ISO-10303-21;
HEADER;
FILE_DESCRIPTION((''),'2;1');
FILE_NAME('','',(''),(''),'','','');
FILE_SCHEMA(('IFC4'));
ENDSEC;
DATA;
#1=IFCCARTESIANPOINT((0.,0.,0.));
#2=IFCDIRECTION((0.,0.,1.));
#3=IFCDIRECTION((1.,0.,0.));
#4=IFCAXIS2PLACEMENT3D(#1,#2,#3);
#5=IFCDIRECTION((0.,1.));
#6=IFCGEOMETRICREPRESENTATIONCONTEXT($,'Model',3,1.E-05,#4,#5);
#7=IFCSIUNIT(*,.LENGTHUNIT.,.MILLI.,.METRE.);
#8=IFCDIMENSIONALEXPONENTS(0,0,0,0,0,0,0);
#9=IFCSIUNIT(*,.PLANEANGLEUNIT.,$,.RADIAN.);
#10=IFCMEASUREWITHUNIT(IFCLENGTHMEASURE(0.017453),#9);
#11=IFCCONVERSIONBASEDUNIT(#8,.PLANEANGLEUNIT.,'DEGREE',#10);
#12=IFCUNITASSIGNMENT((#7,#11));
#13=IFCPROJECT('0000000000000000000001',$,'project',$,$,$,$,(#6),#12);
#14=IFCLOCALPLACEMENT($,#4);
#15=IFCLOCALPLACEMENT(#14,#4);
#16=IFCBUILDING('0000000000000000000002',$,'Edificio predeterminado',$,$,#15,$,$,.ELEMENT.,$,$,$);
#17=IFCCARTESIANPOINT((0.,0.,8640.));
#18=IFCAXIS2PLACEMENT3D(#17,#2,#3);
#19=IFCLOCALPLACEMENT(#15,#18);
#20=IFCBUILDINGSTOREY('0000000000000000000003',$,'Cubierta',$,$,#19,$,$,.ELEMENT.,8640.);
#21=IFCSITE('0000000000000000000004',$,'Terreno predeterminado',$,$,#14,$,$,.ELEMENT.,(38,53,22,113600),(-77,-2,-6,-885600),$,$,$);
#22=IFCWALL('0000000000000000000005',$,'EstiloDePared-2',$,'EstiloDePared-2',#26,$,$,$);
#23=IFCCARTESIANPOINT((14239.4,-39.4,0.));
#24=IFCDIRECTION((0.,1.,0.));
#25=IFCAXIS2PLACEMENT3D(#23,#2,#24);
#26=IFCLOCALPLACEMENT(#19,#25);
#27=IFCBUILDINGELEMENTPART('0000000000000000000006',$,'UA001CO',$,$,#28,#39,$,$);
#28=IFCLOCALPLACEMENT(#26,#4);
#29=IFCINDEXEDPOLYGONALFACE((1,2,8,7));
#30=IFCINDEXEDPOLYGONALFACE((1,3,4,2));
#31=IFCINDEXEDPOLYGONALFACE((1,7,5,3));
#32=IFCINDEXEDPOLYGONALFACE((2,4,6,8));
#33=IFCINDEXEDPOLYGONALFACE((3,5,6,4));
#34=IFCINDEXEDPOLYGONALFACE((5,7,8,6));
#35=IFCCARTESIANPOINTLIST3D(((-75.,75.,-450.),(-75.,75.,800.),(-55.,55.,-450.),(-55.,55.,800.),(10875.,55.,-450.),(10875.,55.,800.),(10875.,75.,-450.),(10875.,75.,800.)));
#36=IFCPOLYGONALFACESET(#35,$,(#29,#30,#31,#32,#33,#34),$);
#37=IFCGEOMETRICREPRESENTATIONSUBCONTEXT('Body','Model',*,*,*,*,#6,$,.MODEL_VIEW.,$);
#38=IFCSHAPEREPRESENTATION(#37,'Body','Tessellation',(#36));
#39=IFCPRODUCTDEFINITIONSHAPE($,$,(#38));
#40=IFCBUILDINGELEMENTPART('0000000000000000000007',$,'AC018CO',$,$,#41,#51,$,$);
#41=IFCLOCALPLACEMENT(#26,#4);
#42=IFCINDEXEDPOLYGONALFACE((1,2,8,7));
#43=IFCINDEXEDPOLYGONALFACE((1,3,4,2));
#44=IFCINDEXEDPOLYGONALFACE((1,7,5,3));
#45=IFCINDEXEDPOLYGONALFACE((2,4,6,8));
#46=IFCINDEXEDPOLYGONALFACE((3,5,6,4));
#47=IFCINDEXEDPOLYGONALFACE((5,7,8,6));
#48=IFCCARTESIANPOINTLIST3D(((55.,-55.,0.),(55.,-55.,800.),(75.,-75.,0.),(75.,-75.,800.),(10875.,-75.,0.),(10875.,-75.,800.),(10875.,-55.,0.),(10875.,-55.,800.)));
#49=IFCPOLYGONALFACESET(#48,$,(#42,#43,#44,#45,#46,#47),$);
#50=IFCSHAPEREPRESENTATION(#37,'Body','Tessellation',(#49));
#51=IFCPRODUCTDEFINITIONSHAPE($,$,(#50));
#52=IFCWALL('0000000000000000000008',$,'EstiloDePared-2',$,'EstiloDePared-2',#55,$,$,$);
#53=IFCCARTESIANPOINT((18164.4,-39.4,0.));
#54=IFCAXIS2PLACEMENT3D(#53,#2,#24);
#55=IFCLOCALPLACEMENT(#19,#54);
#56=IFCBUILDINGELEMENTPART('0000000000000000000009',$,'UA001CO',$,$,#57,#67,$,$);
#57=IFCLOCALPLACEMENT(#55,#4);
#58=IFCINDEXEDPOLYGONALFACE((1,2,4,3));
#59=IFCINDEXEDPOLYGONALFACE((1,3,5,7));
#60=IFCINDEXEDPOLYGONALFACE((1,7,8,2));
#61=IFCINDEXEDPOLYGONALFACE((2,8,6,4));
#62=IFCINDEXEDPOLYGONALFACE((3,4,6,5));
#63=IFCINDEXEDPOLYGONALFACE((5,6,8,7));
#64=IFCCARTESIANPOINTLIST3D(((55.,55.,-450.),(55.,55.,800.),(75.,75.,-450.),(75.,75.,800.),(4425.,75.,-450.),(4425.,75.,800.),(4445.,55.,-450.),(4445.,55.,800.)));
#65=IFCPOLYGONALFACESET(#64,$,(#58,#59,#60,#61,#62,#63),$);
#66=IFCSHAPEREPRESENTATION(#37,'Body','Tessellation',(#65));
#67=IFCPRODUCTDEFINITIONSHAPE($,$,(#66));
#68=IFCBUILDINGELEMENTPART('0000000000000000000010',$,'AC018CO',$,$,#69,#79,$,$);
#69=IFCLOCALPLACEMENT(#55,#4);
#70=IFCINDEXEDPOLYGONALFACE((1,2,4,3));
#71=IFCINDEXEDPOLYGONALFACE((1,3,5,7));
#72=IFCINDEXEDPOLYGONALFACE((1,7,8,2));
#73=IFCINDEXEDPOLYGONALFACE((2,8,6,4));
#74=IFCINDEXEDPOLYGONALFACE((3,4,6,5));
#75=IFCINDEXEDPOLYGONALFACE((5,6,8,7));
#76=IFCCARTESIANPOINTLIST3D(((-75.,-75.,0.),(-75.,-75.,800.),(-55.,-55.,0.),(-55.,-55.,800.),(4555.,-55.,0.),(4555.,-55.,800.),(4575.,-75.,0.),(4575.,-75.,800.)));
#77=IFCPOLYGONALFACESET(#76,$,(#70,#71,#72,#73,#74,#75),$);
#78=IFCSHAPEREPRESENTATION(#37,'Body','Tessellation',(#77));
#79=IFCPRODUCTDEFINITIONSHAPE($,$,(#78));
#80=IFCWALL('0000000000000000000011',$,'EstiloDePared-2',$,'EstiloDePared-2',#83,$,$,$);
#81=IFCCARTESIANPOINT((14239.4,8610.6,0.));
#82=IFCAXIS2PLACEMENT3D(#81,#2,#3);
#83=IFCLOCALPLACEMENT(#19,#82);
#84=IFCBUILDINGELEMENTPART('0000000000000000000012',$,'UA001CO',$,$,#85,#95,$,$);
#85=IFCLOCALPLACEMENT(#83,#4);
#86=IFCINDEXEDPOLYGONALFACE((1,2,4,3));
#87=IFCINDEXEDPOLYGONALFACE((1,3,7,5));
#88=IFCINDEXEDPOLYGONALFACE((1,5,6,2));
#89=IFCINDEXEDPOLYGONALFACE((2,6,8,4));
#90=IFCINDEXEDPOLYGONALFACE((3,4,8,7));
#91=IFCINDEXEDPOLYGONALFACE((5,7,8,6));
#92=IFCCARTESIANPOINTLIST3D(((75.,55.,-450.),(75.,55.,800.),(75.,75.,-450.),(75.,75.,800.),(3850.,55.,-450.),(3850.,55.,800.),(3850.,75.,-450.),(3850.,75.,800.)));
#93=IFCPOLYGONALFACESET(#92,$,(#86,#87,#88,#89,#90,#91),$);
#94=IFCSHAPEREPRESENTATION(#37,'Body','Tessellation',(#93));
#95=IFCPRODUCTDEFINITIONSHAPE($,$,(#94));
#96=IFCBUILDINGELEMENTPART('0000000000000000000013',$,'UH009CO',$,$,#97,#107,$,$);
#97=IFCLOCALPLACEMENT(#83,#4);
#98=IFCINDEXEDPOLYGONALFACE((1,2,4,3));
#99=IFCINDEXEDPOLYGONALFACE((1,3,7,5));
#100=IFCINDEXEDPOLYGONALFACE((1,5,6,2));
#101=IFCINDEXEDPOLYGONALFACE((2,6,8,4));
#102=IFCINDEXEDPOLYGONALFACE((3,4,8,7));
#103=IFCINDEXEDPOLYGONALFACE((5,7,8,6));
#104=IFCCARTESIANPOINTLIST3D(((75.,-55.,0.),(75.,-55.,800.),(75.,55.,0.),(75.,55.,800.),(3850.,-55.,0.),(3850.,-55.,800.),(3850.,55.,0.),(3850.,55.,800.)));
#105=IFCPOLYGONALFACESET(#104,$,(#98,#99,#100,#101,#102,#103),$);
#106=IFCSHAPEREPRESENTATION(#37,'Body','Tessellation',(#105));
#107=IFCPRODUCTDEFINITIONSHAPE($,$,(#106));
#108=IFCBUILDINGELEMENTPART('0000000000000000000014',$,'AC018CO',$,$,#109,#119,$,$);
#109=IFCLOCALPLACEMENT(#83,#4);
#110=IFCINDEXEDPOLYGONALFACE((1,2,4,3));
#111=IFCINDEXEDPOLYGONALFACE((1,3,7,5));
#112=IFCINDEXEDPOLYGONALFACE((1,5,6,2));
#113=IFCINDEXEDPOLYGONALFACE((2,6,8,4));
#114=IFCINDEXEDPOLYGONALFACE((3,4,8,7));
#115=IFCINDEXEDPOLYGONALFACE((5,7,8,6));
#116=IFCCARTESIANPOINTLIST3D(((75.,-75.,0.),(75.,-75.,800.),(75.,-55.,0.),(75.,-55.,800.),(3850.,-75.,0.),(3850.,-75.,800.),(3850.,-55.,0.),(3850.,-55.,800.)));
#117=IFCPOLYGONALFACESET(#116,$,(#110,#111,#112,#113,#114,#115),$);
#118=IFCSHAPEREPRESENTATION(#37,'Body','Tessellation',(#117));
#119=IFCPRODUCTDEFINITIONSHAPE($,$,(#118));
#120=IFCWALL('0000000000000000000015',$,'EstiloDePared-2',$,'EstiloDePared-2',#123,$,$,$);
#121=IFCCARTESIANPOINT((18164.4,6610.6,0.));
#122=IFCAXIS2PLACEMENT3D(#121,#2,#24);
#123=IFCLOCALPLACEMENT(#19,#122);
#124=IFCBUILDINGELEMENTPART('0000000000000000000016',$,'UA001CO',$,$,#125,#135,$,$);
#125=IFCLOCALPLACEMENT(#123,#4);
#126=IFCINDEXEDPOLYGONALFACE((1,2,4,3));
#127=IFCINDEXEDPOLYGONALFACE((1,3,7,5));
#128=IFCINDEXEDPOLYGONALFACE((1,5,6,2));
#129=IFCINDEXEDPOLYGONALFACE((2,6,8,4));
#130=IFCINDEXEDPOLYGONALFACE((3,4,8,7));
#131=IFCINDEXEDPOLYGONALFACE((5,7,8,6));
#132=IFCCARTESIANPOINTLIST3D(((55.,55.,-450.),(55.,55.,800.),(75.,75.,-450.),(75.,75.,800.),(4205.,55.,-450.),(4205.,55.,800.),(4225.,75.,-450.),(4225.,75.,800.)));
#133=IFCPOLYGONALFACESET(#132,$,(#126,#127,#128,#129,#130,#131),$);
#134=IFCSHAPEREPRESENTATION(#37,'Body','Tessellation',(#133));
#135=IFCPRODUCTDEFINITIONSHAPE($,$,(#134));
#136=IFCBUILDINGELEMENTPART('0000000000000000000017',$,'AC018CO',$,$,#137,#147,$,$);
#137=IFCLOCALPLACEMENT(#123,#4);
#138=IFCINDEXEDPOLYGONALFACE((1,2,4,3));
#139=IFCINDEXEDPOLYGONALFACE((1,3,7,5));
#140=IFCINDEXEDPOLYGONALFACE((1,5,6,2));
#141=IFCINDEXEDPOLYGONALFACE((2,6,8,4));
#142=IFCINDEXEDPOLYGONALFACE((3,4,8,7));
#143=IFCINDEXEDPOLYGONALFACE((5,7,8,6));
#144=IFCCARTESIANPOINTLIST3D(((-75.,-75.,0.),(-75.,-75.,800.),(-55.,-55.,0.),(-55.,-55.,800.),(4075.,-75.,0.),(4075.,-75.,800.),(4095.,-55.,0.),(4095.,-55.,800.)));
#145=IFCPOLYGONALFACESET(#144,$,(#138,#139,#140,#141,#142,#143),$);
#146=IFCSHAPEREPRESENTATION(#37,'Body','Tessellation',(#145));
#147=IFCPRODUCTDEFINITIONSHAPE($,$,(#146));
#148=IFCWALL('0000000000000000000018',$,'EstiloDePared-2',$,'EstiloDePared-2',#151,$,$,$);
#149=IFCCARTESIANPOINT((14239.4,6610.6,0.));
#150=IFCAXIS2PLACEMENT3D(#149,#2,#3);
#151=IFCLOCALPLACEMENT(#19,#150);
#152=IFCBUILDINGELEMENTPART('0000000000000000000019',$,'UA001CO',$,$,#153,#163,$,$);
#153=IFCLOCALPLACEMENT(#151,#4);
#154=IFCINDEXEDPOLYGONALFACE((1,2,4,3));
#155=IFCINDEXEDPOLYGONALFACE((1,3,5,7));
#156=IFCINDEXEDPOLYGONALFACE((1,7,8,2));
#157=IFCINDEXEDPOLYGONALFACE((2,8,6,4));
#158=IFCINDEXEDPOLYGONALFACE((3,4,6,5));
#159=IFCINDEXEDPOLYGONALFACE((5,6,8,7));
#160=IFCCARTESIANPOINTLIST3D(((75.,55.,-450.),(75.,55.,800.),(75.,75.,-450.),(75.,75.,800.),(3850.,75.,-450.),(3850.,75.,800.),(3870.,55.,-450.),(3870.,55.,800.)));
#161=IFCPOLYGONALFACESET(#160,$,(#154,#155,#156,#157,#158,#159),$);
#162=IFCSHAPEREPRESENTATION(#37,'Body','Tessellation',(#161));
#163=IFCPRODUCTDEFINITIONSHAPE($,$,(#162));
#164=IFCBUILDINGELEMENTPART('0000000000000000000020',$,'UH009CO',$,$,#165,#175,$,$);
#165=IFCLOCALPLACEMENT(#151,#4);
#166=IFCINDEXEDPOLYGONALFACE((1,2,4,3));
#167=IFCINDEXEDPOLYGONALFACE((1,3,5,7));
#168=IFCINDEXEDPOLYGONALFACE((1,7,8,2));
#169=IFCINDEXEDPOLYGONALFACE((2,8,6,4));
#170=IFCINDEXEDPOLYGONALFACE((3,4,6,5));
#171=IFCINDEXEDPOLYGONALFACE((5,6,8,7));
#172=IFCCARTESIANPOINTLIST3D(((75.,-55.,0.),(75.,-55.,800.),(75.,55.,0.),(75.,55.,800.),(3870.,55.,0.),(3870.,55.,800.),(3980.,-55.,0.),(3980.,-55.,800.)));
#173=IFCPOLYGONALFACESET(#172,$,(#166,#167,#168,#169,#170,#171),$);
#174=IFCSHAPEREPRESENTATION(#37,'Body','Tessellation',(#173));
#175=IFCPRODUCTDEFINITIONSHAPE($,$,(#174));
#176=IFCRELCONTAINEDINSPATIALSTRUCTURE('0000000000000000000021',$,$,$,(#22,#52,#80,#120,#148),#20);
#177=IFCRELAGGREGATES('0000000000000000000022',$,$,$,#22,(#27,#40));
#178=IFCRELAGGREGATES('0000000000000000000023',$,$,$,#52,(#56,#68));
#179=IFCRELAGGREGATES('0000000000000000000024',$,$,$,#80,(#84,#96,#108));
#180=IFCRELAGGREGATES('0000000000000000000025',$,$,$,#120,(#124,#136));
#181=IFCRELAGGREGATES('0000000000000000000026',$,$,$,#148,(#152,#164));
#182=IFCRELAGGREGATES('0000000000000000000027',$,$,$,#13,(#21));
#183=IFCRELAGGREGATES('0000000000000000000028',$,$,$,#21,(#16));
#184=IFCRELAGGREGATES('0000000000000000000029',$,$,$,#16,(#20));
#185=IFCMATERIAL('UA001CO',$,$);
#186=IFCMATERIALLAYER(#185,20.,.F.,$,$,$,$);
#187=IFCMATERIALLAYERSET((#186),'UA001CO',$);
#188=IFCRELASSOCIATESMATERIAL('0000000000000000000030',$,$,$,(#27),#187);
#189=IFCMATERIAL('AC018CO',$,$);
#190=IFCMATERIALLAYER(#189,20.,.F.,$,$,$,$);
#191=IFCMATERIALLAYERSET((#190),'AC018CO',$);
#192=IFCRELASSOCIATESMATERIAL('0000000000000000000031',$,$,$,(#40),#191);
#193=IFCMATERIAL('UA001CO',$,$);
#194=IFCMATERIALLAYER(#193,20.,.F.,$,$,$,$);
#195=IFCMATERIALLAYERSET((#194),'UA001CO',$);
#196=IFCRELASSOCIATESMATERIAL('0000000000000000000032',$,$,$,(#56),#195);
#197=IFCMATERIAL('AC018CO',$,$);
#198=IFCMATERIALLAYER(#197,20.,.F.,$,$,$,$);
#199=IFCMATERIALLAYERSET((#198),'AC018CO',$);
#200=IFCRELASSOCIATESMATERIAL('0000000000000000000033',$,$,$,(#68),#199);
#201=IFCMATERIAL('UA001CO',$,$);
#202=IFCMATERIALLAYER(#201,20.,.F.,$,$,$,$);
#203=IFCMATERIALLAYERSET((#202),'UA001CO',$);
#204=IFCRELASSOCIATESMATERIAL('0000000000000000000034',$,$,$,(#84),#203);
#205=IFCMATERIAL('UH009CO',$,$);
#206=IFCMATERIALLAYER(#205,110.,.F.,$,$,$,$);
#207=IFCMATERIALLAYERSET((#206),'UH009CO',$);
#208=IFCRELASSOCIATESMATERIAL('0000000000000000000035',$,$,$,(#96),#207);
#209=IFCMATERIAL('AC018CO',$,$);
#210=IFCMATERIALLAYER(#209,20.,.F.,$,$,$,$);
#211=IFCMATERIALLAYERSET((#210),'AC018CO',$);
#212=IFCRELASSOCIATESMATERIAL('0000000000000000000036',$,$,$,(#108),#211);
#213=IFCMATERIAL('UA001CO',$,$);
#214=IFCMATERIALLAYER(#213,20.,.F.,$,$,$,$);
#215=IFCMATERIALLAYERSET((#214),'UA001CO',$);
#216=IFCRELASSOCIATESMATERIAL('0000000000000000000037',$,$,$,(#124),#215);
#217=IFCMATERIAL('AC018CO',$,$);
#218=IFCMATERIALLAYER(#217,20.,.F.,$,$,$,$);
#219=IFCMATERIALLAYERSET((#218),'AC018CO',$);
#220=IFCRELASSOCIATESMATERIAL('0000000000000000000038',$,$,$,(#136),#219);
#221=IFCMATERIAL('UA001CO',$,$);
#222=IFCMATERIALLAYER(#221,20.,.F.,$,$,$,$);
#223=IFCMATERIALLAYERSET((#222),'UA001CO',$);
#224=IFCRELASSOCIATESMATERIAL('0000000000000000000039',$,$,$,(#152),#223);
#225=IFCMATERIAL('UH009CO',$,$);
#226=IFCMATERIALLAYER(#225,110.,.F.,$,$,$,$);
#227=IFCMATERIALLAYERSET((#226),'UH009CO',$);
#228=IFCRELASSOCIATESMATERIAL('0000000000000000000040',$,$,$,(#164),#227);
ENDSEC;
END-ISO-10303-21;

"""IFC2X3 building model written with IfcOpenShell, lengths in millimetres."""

from ifc_helpers import new_model, entity, si_unit, converted_unit, direction, frame, origin_with_axes, place, context, subcontext, project, spatial, polyline, outline, extrude, material, layer, layer_set, layer_usage, element, aggregate, save


model = new_model("IFC2X3")

# Units and contexts
model_context = context("Model", 3, precision=1e-05, world=origin_with_axes(), true_north=direction((0.0, 1.0)))
body_context = subcontext(model_context, "Body", "Model", "MODEL_VIEW")
ifc_project = project(units=[si_unit("LENGTHUNIT", "METRE", prefix="MILLI"), converted_unit("PLANEANGLEUNIT", "DEGREE", entity("IfcLengthMeasure", 0.017453), si_unit("PLANEANGLEUNIT", "RADIAN"), dimensions=[0, 0, 0, 0, 0, 0, 0])], contexts=[model_context])

# Site, building, storey
site_placement = place(None, origin_with_axes())
site = spatial("IfcSite", under=ifc_project, at=site_placement, Name="Terreno predeterminado", CompositionType="ELEMENT", RefLatitude=(38, 53, 22, 113600), RefLongitude=(-77, -2, -6, -885600))
building_placement = place(site_placement, origin_with_axes())
building = spatial("IfcBuilding", under=site, at=building_placement, Name="Edificio predeterminado", CompositionType="ELEMENT")
storey_placement = place(building_placement, frame((0.0, 0.0, 8640.0), z_axis=(0.0, 0.0, 1.0), x_axis=(1.0, 0.0, 0.0)))
storey = spatial("IfcBuildingStorey", under=building, at=storey_placement, Name="Cubierta", CompositionType="ELEMENT", Elevation=8640.0)

# Walls, building element parts
wall_1_placement = place(storey_placement, frame((14239.4, -39.4, 0.0), z_axis=(0.0, 0.0, 1.0), x_axis=(0.0, 1.0, 0.0)))
wall_1 = element("IfcWall", 1, at=wall_1_placement, inside=storey, Name="EstiloDePared-2", ObjectType="EstiloDePared-2")
ifc_material_1 = material(Name="UA001CO")
ifc_layer_1 = layer(ifc_material_1, 20.0, ventilated=False)
ifc_layer_set_1 = layer_set([ifc_layer_1], Name="UA001CO")
ifc_layer_usage_1 = layer_usage(ifc_layer_set_1, "AXIS2", "NEGATIVE", -75.0)
building_element_part_1_placement = place(wall_1_placement, origin_with_axes())
building_element_part_1 = element("IfcBuildingElementPart", 2, at=building_element_part_1_placement, material=ifc_layer_usage_1, Name="UA001CO", context=body_context, shape_type="SweptSolid", body=[
    extrude(outline(polyline([(10875.0, 75.0), (10875.0, 55.0), (-55.0, 55.0), (-75.0, 75.0), (10875.0, 75.0)])), frame((0.0, 0.0, -450.0), z_axis=(0.0, 0.0, 1.0), x_axis=(1.0, 0.0, 0.0)), (0.0, 0.0, 1.0), 1250.0),
])
ifc_material_2 = material(Name="AC018CO")
ifc_layer_2 = layer(ifc_material_2, 20.0, ventilated=False)
ifc_layer_set_2 = layer_set([ifc_layer_2], Name="AC018CO")
ifc_layer_usage_2 = layer_usage(ifc_layer_set_2, "AXIS2", "NEGATIVE", 55.0)
building_element_part_2_placement = place(wall_1_placement, origin_with_axes())
building_element_part_2 = element("IfcBuildingElementPart", 3, at=building_element_part_2_placement, material=ifc_layer_usage_2, Name="AC018CO", context=body_context, shape_type="SweptSolid", body=[
    extrude(outline(polyline([(10875.0, -55.0), (10875.0, -75.0), (75.0, -75.0), (55.0, -55.0), (10875.0, -55.0)])), origin_with_axes(), (0.0, 0.0, 1.0), 800.0),
])
aggregate(wall_1, [building_element_part_1, building_element_part_2])
wall_2_placement = place(storey_placement, frame((18164.4, -39.4, 0.0), z_axis=(0.0, 0.0, 1.0), x_axis=(0.0, 1.0, 0.0)))
wall_2 = element("IfcWall", 4, at=wall_2_placement, inside=storey, Name="EstiloDePared-2", ObjectType="EstiloDePared-2")
ifc_material_3 = material(Name="UA001CO")
ifc_layer_3 = layer(ifc_material_3, 20.0, ventilated=False)
ifc_layer_set_3 = layer_set([ifc_layer_3], Name="UA001CO")
ifc_layer_usage_3 = layer_usage(ifc_layer_set_3, "AXIS2", "NEGATIVE", -75.0)
building_element_part_3_placement = place(wall_2_placement, origin_with_axes())
building_element_part_3 = element("IfcBuildingElementPart", 5, at=building_element_part_3_placement, material=ifc_layer_usage_3, Name="UA001CO", context=body_context, shape_type="SweptSolid", body=[
    extrude(outline(polyline([(4425.0, 75.0), (4445.0, 55.0), (55.0, 55.0), (75.0, 75.0), (4425.0, 75.0)])), frame((0.0, 0.0, -450.0), z_axis=(0.0, 0.0, 1.0), x_axis=(1.0, 0.0, 0.0)), (0.0, 0.0, 1.0), 1250.0),
])
ifc_material_4 = material(Name="AC018CO")
ifc_layer_4 = layer(ifc_material_4, 20.0, ventilated=False)
ifc_layer_set_4 = layer_set([ifc_layer_4], Name="AC018CO")
ifc_layer_usage_4 = layer_usage(ifc_layer_set_4, "AXIS2", "NEGATIVE", 55.0)
building_element_part_4_placement = place(wall_2_placement, origin_with_axes())
building_element_part_4 = element("IfcBuildingElementPart", 6, at=building_element_part_4_placement, material=ifc_layer_usage_4, Name="AC018CO", context=body_context, shape_type="SweptSolid", body=[
    extrude(outline(polyline([(4555.0, -55.0), (4575.0, -75.0), (-75.0, -75.0), (-55.0, -55.0), (4555.0, -55.0)])), origin_with_axes(), (0.0, 0.0, 1.0), 800.0),
])
aggregate(wall_2, [building_element_part_3, building_element_part_4])
wall_3_placement = place(storey_placement, frame((14239.4, 8610.6, 0.0), z_axis=(0.0, 0.0, 1.0), x_axis=(1.0, 0.0, 0.0)))
wall_3 = element("IfcWall", 7, at=wall_3_placement, inside=storey, Name="EstiloDePared-2", ObjectType="EstiloDePared-2")
ifc_material_5 = material(Name="UA001CO")
ifc_layer_5 = layer(ifc_material_5, 20.0, ventilated=False)
ifc_layer_set_5 = layer_set([ifc_layer_5], Name="UA001CO")
ifc_layer_usage_5 = layer_usage(ifc_layer_set_5, "AXIS2", "NEGATIVE", -75.0)
building_element_part_5_placement = place(wall_3_placement, origin_with_axes())
building_element_part_5 = element("IfcBuildingElementPart", 8, at=building_element_part_5_placement, material=ifc_layer_usage_5, Name="UA001CO", context=body_context, shape_type="SweptSolid", body=[
    extrude(outline(polyline([(3850.0, 75.0), (3850.0, 55.0), (75.0, 55.0), (75.0, 75.0), (3850.0, 75.0)])), frame((0.0, 0.0, -450.0), z_axis=(0.0, 0.0, 1.0), x_axis=(1.0, 0.0, 0.0)), (0.0, 0.0, 1.0), 1250.0),
])
ifc_material_6 = material(Name="UH009CO")
ifc_layer_6 = layer(ifc_material_6, 110.0, ventilated=False)
ifc_layer_set_6 = layer_set([ifc_layer_6], Name="UH009CO")
ifc_layer_usage_6 = layer_usage(ifc_layer_set_6, "AXIS2", "NEGATIVE", -55.0)
building_element_part_6_placement = place(wall_3_placement, origin_with_axes())
building_element_part_6 = element("IfcBuildingElementPart", 9, at=building_element_part_6_placement, material=ifc_layer_usage_6, Name="UH009CO", context=body_context, shape_type="SweptSolid", body=[
    extrude(outline(polyline([(3850.0, 55.0), (3850.0, -55.0), (75.0, -55.0), (75.0, 55.0), (3850.0, 55.0)])), origin_with_axes(), (0.0, 0.0, 1.0), 800.0),
])
ifc_material_7 = material(Name="AC018CO")
ifc_layer_7 = layer(ifc_material_7, 20.0, ventilated=False)
ifc_layer_set_7 = layer_set([ifc_layer_7], Name="AC018CO")
ifc_layer_usage_7 = layer_usage(ifc_layer_set_7, "AXIS2", "NEGATIVE", 55.0)
building_element_part_7_placement = place(wall_3_placement, origin_with_axes())
building_element_part_7 = element("IfcBuildingElementPart", 10, at=building_element_part_7_placement, material=ifc_layer_usage_7, Name="AC018CO", context=body_context, shape_type="SweptSolid", body=[
    extrude(outline(polyline([(3850.0, -55.0), (3850.0, -75.0), (75.0, -75.0), (75.0, -55.0), (3850.0, -55.0)])), origin_with_axes(), (0.0, 0.0, 1.0), 800.0),
])
aggregate(wall_3, [building_element_part_5, building_element_part_6, building_element_part_7])
wall_4_placement = place(storey_placement, frame((18164.4, 6610.6, 0.0), z_axis=(0.0, 0.0, 1.0), x_axis=(0.0, 1.0, 0.0)))
wall_4 = element("IfcWall", 11, at=wall_4_placement, inside=storey, Name="EstiloDePared-2", ObjectType="EstiloDePared-2")
ifc_material_8 = material(Name="UA001CO")
ifc_layer_8 = layer(ifc_material_8, 20.0, ventilated=False)
ifc_layer_set_8 = layer_set([ifc_layer_8], Name="UA001CO")
ifc_layer_usage_8 = layer_usage(ifc_layer_set_8, "AXIS2", "NEGATIVE", -75.0)
building_element_part_8_placement = place(wall_4_placement, origin_with_axes())
building_element_part_8 = element("IfcBuildingElementPart", 12, at=building_element_part_8_placement, material=ifc_layer_usage_8, Name="UA001CO", context=body_context, shape_type="SweptSolid", body=[
    extrude(outline(polyline([(4225.0, 75.0), (4205.0, 55.0), (55.0, 55.0), (75.0, 75.0), (4225.0, 75.0)])), frame((0.0, 0.0, -450.0), z_axis=(0.0, 0.0, 1.0), x_axis=(1.0, 0.0, 0.0)), (0.0, 0.0, 1.0), 1250.0),
])
ifc_material_9 = material(Name="AC018CO")
ifc_layer_9 = layer(ifc_material_9, 20.0, ventilated=False)
ifc_layer_set_9 = layer_set([ifc_layer_9], Name="AC018CO")
ifc_layer_usage_9 = layer_usage(ifc_layer_set_9, "AXIS2", "NEGATIVE", 55.0)
building_element_part_9_placement = place(wall_4_placement, origin_with_axes())
building_element_part_9 = element("IfcBuildingElementPart", 13, at=building_element_part_9_placement, material=ifc_layer_usage_9, Name="AC018CO", context=body_context, shape_type="SweptSolid", body=[
    extrude(outline(polyline([(4095.0, -55.0), (4075.0, -75.0), (-75.0, -75.0), (-55.0, -55.0), (4095.0, -55.0)])), origin_with_axes(), (0.0, 0.0, 1.0), 800.0),
])
aggregate(wall_4, [building_element_part_8, building_element_part_9])
wall_5_placement = place(storey_placement, frame((14239.4, 6610.6, 0.0), z_axis=(0.0, 0.0, 1.0), x_axis=(1.0, 0.0, 0.0)))
wall_5 = element("IfcWall", 14, at=wall_5_placement, inside=storey, Name="EstiloDePared-2", ObjectType="EstiloDePared-2")
ifc_material_10 = material(Name="UA001CO")
ifc_layer_10 = layer(ifc_material_10, 20.0, ventilated=False)
ifc_layer_set_10 = layer_set([ifc_layer_10], Name="UA001CO")
ifc_layer_usage_10 = layer_usage(ifc_layer_set_10, "AXIS2", "NEGATIVE", -75.0)
building_element_part_10_placement = place(wall_5_placement, origin_with_axes())
building_element_part_10 = element("IfcBuildingElementPart", 15, at=building_element_part_10_placement, material=ifc_layer_usage_10, Name="UA001CO", context=body_context, shape_type="SweptSolid", body=[
    extrude(outline(polyline([(3850.0, 75.0), (3870.0, 55.0), (75.0, 55.0), (75.0, 75.0), (3850.0, 75.0)])), frame((0.0, 0.0, -450.0), z_axis=(0.0, 0.0, 1.0), x_axis=(1.0, 0.0, 0.0)), (0.0, 0.0, 1.0), 1250.0),
])
ifc_material_11 = material(Name="UH009CO")
ifc_layer_11 = layer(ifc_material_11, 110.0, ventilated=False)
ifc_layer_set_11 = layer_set([ifc_layer_11], Name="UH009CO")
ifc_layer_usage_11 = layer_usage(ifc_layer_set_11, "AXIS2", "NEGATIVE", -55.0)
building_element_part_11_placement = place(wall_5_placement, origin_with_axes())
building_element_part_11 = element("IfcBuildingElementPart", 16, at=building_element_part_11_placement, material=ifc_layer_usage_11, Name="UH009CO", context=body_context, shape_type="SweptSolid", body=[
    extrude(outline(polyline([(3870.0, 55.0), (3980.0, -55.0), (75.0, -55.0), (75.0, 55.0), (3870.0, 55.0)])), origin_with_axes(), (0.0, 0.0, 1.0), 800.0),
])
aggregate(wall_5, [building_element_part_10, building_element_part_11])

save(model, "model.ifc")
